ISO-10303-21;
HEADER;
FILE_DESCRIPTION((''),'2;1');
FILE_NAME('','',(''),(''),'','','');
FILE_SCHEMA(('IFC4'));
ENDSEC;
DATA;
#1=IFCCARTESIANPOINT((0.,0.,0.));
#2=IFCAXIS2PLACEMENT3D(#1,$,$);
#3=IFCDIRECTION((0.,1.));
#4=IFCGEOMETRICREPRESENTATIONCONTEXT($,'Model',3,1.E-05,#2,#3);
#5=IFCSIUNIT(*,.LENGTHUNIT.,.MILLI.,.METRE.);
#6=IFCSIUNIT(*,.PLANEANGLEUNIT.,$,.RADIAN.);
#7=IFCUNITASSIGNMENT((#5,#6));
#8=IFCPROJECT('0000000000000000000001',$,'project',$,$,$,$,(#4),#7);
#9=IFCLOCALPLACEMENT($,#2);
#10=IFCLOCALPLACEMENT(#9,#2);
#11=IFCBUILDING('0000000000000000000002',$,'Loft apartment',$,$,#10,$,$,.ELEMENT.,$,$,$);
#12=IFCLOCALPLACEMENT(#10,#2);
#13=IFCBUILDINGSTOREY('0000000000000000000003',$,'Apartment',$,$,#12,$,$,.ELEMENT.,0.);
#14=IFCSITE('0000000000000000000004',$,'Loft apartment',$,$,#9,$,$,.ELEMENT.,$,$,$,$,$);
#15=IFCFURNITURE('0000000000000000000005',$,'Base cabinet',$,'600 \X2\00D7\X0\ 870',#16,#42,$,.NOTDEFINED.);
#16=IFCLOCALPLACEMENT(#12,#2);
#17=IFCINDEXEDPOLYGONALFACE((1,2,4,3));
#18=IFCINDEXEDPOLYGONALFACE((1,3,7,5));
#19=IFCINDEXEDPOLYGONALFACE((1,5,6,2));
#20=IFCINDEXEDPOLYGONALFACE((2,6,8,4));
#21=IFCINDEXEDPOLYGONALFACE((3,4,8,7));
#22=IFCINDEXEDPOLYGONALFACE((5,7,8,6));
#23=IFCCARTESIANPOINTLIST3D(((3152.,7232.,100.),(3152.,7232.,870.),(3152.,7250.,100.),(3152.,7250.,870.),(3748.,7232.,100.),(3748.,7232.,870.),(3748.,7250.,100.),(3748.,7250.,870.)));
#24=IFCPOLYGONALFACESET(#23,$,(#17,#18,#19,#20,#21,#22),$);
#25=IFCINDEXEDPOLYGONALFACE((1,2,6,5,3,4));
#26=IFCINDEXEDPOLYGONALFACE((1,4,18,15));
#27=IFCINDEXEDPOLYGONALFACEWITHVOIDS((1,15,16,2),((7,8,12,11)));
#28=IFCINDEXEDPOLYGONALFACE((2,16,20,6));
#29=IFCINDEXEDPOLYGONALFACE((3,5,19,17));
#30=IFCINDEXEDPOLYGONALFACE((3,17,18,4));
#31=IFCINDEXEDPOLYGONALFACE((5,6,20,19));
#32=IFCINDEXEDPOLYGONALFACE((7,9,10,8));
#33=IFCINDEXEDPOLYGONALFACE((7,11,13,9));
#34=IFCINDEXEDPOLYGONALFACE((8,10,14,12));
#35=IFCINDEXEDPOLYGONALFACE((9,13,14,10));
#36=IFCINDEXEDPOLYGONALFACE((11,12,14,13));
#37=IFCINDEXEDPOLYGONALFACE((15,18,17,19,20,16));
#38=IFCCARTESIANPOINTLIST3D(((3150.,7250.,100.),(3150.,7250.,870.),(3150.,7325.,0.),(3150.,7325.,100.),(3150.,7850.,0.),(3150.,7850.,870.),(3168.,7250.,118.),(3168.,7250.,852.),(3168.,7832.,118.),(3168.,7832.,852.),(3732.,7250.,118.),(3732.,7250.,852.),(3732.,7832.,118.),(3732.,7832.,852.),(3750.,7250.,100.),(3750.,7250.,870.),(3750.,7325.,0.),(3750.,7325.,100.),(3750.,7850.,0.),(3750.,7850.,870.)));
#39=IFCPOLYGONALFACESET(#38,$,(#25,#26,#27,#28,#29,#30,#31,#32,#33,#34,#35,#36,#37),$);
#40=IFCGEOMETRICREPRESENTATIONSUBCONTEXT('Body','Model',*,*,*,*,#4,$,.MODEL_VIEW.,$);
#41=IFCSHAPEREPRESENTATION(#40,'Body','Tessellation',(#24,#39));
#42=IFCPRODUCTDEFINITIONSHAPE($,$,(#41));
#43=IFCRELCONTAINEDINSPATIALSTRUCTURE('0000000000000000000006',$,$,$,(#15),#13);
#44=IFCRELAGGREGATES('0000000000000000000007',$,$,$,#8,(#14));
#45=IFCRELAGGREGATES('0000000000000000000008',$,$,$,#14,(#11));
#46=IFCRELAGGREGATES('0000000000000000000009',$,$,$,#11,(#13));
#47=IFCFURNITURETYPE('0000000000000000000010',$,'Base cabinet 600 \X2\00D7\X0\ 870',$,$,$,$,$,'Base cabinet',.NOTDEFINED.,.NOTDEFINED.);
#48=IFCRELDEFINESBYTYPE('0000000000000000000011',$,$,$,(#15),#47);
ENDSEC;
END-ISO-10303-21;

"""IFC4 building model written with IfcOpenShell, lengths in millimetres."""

from ifc_helpers import new_model, entity, si_unit, direction, frame, origin, place, context, subcontext, project, spatial, polyline, outline, extrude, source, transform, mapped, type_object, type_shapes, element, save


model = new_model("IFC4")

# Units and contexts
model_context = context("Model", 3, precision=1e-05, world=origin(), true_north=direction((0.0, 1.0)))
body_context = subcontext(model_context, "Body", "Model", "MODEL_VIEW")
ifc_project = project(units=[si_unit("LENGTHUNIT", "METRE", prefix="MILLI"), si_unit("PLANEANGLEUNIT", "RADIAN")], contexts=[model_context])

# Site, building, storey
site_placement = place(None, origin())
site = spatial("IfcSite", under=ifc_project, at=site_placement, Name="Loft apartment", CompositionType="ELEMENT")
building_placement = place(site_placement, origin())
building = spatial("IfcBuilding", under=site, at=building_placement, Name="Loft apartment", CompositionType="ELEMENT")
storey_placement = place(building_placement, origin())
storey = spatial("IfcBuildingStorey", under=building, at=storey_placement, Name="Apartment", CompositionType="ELEMENT", Elevation=0.0)

# Furniture
furniture_type_1 = type_object("IfcFurnitureType", Name="Base cabinet 600 × 870", ElementType="Base cabinet", AssemblyPlace="NOTDEFINED", PredefinedType="NOTDEFINED")
cartesian_point_1 = entity("IfcCartesianPoint", [-300.0, 0.0])
cartesian_point_2 = entity("IfcCartesianPoint", [-282.0, -1.0])
cartesian_point_3 = entity("IfcCartesianPoint", [-301.0, -1.0])
shared_shape_1 = source(origin(), body_context, "Body", "SolidModel", [
    extrude(outline(polyline([(-298.0, -18.0), (298.0, -18.0), (298.0, 0.0), (-298.0, 0.0), (-298.0, -18.0)])), frame((0.0, 0.0, 100.0)), (0.0, 0.0, 1.0), 770.0),
    entity("IfcCsgSolid", entity("IfcBooleanResult", "DIFFERENCE", entity("IfcBooleanResult", "DIFFERENCE", entity("IfcExtrudedAreaSolid", entity("IfcArbitraryClosedProfileDef", "AREA", None, entity("IfcPolyline", [cartesian_point_1, entity("IfcCartesianPoint", [300.0, 0.0]), entity("IfcCartesianPoint", [300.0, 600.0]), entity("IfcCartesianPoint", [-300.0, 600.0]), cartesian_point_1])), entity("IfcAxis2Placement3D", entity("IfcCartesianPoint", [0.0, 0.0, 0.0])), entity("IfcDirection", [0.0, 0.0, 1.0]), 870.0), entity("IfcExtrudedAreaSolid", entity("IfcArbitraryClosedProfileDef", "AREA", None, entity("IfcPolyline", [cartesian_point_2, entity("IfcCartesianPoint", [282.0, -1.0]), entity("IfcCartesianPoint", [282.0, 582.0]), entity("IfcCartesianPoint", [-282.0, 582.0]), cartesian_point_2])), entity("IfcAxis2Placement3D", entity("IfcCartesianPoint", [0.0, 0.0, 118.0])), entity("IfcDirection", [0.0, 0.0, 1.0]), 734.0)), entity("IfcExtrudedAreaSolid", entity("IfcArbitraryClosedProfileDef", "AREA", None, entity("IfcPolyline", [cartesian_point_3, entity("IfcCartesianPoint", [301.0, -1.0]), entity("IfcCartesianPoint", [301.0, 75.0]), entity("IfcCartesianPoint", [-301.0, 75.0]), cartesian_point_3])), entity("IfcAxis2Placement3D", entity("IfcCartesianPoint", [0.0, 0.0, -1.0])), entity("IfcDirection", [0.0, 0.0, 1.0]), 101.0))),
])
type_shapes(furniture_type_1, [shared_shape_1])
for number, where, z_axis, x_axis, name in (
    (1, (3450.0, 7250.0, 0.0), (0.0, 0.0, 1.0), (1.0, 0.0, 0.0), "Base cabinet"),
):
    element("IfcFurniture", number, at=place(storey_placement, frame(where, z_axis=z_axis, x_axis=x_axis)), inside=storey, type_object=furniture_type_1, Name=name, ObjectType="600 × 870", PredefinedType="NOTDEFINED", context=body_context, shape_type="MappedRepresentation", body=[
        mapped(shared_shape_1, transform((0.0, 0.0, 0.0))),
    ])

save(model, "model.ifc")
